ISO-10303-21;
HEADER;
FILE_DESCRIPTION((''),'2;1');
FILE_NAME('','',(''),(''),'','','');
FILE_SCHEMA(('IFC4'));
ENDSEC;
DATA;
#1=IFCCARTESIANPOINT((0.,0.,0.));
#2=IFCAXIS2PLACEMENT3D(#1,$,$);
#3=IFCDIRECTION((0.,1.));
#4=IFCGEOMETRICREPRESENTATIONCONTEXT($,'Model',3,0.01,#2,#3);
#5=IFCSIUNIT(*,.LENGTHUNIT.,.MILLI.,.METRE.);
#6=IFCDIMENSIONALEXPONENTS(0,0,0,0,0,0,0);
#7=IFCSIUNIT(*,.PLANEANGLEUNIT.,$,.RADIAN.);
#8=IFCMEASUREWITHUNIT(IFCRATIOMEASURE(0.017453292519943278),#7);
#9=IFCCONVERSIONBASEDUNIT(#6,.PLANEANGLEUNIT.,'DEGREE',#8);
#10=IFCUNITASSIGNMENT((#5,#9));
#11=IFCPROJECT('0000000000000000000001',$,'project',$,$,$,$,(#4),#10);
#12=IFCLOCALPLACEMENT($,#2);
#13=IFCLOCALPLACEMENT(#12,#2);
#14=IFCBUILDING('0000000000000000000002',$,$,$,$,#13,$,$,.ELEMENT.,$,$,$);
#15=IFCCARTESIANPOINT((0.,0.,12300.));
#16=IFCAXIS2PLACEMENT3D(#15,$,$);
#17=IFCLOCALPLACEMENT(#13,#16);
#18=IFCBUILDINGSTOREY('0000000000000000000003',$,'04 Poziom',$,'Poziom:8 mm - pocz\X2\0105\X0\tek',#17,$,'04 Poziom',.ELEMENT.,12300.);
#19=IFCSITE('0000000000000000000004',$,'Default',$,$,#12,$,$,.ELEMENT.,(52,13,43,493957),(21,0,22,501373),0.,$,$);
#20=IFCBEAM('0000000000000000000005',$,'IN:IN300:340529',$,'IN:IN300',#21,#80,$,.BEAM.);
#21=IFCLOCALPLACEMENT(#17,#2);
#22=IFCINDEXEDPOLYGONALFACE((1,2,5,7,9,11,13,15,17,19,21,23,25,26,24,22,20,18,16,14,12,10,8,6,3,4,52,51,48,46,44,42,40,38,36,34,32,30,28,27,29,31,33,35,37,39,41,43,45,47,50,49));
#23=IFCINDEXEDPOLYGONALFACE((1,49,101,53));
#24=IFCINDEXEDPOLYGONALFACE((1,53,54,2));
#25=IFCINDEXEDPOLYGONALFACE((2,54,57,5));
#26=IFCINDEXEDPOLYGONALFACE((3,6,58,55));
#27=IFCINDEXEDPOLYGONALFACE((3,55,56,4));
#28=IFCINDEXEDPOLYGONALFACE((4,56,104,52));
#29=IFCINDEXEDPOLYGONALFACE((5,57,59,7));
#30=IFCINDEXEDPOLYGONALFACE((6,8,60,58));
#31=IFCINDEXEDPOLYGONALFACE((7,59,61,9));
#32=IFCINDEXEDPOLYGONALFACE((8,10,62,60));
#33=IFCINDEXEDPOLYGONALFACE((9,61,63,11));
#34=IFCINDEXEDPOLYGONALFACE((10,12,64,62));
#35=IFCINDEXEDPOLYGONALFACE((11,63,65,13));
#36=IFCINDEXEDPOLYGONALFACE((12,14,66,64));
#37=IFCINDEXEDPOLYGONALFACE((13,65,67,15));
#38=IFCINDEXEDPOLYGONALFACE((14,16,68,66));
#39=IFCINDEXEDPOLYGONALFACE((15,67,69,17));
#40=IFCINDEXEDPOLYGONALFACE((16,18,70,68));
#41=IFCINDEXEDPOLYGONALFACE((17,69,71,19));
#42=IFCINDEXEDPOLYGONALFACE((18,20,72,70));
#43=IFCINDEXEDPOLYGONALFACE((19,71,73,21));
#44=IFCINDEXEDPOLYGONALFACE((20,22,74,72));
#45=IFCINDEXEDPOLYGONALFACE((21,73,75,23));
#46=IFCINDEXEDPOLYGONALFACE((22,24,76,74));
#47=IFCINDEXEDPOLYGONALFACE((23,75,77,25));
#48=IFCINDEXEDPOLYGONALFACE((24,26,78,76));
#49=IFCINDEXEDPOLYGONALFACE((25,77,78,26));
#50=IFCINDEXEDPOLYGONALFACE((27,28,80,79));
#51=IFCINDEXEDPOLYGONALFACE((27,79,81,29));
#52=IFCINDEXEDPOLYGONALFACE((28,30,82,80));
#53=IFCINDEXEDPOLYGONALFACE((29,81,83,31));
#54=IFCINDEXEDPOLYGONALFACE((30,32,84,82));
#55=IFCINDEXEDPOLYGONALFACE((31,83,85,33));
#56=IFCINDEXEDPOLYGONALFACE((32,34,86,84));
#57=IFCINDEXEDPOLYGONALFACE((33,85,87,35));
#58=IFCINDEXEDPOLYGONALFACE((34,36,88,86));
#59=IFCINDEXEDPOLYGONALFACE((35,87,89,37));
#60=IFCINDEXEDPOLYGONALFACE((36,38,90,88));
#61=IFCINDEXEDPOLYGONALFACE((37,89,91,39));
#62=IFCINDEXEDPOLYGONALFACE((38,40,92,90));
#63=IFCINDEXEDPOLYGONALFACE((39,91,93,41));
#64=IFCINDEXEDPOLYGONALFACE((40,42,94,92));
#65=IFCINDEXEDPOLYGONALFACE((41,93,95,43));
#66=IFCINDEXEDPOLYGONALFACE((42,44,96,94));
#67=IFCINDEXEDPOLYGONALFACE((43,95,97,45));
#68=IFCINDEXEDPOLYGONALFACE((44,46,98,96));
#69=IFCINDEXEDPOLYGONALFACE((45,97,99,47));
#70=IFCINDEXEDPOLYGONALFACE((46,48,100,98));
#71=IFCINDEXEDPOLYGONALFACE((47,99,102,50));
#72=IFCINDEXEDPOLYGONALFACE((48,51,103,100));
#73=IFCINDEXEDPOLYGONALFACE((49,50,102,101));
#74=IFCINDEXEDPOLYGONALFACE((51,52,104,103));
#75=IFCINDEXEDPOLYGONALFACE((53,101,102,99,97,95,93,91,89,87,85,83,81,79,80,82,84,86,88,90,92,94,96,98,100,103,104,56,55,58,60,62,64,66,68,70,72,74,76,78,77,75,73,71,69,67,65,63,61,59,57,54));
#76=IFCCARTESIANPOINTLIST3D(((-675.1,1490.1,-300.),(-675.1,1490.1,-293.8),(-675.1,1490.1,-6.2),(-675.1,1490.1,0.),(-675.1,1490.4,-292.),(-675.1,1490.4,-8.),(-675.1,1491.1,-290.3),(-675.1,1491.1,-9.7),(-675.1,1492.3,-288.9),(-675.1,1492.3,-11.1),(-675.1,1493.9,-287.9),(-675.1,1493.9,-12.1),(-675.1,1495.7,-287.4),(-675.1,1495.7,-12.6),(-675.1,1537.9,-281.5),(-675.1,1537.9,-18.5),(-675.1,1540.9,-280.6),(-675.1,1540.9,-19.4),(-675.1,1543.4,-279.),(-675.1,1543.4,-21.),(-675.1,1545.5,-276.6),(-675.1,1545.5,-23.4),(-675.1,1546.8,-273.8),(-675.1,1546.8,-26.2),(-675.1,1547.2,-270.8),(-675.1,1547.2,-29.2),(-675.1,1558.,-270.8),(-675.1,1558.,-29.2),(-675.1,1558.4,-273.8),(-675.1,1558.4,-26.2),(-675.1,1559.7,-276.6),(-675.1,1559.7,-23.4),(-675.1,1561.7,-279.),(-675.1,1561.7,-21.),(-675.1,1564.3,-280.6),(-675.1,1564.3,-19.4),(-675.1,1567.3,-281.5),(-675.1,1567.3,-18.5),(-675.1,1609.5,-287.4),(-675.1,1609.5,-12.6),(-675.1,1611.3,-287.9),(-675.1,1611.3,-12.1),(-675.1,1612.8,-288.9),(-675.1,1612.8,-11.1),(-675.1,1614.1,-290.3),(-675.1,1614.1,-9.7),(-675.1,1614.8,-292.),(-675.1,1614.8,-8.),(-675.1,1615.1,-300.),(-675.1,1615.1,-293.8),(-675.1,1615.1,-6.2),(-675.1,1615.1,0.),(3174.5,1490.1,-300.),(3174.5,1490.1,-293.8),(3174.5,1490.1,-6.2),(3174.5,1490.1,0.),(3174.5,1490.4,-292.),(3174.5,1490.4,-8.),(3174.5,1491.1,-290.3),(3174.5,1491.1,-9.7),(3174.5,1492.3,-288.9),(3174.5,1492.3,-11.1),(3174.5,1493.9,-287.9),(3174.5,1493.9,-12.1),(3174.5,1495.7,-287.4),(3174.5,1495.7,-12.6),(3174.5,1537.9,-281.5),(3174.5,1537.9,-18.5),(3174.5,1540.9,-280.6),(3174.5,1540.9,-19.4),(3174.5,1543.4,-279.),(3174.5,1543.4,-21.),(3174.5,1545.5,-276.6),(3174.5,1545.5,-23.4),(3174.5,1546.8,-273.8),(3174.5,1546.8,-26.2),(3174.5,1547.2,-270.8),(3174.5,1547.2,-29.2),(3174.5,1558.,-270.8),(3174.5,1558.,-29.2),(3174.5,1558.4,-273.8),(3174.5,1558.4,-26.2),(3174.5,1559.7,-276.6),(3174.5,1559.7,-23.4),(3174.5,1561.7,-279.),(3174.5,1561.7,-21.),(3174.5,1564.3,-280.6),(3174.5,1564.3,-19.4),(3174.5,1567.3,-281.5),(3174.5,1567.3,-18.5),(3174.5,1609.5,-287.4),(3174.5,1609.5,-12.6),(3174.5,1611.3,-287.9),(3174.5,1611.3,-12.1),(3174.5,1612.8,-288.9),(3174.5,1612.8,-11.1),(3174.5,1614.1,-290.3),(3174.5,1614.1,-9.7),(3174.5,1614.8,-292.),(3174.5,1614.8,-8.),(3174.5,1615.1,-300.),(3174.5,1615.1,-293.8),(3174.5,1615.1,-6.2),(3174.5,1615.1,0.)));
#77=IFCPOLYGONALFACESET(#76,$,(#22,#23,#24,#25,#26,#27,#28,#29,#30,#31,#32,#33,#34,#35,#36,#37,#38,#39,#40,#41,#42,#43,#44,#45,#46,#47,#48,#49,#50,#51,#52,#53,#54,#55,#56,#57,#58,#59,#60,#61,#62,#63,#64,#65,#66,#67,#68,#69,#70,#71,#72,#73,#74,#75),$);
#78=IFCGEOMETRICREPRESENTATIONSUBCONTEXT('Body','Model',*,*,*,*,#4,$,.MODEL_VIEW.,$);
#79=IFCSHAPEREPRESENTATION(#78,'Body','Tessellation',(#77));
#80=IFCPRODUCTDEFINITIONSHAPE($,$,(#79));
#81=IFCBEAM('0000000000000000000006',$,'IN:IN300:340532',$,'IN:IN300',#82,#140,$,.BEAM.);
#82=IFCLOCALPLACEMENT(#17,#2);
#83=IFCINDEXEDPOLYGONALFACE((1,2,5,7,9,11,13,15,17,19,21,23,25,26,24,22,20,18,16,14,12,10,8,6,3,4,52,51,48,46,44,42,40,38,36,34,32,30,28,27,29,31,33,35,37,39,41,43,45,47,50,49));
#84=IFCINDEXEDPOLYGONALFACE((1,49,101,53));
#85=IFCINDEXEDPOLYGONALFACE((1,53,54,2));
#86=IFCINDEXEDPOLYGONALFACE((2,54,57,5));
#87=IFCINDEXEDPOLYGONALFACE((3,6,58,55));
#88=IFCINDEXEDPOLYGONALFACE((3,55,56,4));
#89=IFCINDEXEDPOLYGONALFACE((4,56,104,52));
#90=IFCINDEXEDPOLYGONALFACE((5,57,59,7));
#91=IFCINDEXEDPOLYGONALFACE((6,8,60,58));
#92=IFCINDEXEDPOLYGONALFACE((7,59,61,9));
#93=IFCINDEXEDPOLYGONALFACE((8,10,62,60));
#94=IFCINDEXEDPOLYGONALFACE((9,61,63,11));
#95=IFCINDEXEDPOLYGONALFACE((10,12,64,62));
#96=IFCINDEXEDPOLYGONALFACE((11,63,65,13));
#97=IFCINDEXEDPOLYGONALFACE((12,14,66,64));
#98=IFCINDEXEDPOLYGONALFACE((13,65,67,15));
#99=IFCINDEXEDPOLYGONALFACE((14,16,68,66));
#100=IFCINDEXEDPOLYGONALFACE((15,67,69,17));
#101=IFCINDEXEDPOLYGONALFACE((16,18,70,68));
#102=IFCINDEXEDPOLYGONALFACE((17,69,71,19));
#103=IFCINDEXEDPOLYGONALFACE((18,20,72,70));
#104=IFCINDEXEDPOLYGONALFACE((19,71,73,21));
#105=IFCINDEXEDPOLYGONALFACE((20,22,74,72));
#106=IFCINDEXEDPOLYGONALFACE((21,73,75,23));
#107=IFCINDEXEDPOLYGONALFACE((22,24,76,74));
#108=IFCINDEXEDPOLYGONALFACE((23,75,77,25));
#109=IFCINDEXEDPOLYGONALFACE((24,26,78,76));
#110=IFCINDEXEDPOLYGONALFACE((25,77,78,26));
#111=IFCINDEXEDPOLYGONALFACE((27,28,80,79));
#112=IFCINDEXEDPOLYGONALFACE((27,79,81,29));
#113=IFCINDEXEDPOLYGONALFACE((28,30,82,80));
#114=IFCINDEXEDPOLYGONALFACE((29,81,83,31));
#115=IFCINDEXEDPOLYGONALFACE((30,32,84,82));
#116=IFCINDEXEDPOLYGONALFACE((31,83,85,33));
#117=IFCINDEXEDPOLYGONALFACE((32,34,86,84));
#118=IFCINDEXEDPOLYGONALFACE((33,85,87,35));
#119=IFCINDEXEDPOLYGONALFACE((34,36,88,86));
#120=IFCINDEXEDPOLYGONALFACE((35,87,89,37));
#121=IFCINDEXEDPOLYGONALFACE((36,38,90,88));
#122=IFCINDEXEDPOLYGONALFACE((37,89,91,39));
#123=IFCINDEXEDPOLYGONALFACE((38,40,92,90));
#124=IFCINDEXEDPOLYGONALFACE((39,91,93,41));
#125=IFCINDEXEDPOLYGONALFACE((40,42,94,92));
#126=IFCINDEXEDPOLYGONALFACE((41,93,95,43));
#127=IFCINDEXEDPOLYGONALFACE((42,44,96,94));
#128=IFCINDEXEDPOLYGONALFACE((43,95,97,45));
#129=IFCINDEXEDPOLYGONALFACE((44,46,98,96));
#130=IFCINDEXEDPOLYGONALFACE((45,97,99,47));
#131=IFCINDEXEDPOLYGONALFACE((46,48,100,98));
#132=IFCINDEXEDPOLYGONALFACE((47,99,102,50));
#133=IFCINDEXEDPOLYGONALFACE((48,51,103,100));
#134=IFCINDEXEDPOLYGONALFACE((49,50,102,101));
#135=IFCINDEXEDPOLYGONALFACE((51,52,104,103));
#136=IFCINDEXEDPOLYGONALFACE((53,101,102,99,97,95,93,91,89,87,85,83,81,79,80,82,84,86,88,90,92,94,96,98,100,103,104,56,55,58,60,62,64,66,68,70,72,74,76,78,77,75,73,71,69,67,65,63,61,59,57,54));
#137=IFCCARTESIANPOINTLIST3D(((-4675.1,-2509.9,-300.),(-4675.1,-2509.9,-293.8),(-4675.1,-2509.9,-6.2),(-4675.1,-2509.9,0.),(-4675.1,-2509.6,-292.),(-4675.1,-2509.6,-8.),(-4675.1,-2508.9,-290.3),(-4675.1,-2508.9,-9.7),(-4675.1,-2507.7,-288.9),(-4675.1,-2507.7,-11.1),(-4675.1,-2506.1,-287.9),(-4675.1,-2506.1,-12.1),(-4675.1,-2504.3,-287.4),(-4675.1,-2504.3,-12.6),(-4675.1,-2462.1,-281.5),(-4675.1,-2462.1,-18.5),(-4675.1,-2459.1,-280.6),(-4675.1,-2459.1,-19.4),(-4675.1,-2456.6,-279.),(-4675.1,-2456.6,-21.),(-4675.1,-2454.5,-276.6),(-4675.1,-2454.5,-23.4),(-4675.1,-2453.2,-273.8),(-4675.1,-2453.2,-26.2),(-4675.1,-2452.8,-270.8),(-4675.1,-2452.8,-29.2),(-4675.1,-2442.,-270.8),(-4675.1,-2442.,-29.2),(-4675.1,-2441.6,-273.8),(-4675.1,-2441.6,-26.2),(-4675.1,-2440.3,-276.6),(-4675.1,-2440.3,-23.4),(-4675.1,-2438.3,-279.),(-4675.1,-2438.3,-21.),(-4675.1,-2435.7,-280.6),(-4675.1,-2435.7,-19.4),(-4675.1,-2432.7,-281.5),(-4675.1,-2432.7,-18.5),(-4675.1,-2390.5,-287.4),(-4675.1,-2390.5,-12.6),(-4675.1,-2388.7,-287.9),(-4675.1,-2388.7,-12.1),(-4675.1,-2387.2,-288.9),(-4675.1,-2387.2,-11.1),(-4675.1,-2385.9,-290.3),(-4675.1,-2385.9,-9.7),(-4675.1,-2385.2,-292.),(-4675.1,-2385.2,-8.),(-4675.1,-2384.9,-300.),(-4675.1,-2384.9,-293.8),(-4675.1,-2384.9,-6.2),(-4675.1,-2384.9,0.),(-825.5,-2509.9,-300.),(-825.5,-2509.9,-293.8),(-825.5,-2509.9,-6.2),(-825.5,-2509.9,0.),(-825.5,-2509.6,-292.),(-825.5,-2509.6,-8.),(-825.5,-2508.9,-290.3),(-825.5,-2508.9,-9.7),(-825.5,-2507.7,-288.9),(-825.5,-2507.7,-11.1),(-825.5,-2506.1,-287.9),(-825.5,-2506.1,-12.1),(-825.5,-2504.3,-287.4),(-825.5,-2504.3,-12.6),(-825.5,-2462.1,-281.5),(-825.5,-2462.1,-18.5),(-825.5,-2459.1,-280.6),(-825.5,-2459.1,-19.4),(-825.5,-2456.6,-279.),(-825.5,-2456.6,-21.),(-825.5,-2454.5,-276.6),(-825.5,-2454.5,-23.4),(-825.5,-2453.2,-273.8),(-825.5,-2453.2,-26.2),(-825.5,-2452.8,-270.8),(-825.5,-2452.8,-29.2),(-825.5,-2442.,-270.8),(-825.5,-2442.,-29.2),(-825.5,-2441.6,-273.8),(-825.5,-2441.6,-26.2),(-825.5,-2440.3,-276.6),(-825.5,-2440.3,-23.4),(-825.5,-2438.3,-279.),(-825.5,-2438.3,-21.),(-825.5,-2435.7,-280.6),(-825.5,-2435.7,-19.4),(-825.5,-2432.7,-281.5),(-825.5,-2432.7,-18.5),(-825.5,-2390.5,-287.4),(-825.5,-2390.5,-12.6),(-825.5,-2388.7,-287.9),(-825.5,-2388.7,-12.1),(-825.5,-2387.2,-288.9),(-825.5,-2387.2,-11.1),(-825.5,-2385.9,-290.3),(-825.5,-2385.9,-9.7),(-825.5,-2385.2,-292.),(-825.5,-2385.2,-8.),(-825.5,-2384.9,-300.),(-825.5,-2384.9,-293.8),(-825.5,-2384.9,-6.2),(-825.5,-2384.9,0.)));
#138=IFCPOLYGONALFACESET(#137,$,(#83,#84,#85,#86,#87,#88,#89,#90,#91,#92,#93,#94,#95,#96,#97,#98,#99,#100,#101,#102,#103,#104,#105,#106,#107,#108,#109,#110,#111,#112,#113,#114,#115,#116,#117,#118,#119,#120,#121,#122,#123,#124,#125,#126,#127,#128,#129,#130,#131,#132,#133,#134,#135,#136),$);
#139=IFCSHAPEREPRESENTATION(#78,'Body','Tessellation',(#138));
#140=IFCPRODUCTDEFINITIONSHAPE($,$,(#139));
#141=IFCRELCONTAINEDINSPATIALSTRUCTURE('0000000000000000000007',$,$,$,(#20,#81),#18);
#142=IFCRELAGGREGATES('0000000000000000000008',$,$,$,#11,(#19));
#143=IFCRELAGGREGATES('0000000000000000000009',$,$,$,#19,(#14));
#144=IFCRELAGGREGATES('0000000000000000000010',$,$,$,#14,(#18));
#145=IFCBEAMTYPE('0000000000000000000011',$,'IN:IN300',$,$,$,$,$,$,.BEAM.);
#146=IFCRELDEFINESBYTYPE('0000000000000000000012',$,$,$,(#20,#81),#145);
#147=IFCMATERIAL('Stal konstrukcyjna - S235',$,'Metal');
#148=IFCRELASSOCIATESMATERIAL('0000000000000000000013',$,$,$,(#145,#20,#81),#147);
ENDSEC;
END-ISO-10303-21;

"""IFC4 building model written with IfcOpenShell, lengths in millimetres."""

from ifc_helpers import new_model, entity, si_unit, converted_unit, direction, frame, origin, place, context, subcontext, project, spatial, line, arc, indexed_curve, outline, extrude, source, transform, mapped, material, type_object, type_shapes, element, save


model = new_model("IFC4")

# Units and contexts
model_context = context("Model", 3, precision=0.01, world=origin(), true_north=direction((0.0, 1.0)))
body_context = subcontext(model_context, "Body", "Model", "MODEL_VIEW")
ifc_project = project(units=[si_unit("LENGTHUNIT", "METRE", prefix="MILLI"), converted_unit("PLANEANGLEUNIT", "DEGREE", entity("IfcRatioMeasure", 0.017453292519943278), si_unit("PLANEANGLEUNIT", "RADIAN"), dimensions=[0, 0, 0, 0, 0, 0, 0])], contexts=[model_context])

# Site, building, storey
site_placement = place(None, origin())
site = spatial("IfcSite", under=ifc_project, at=site_placement, Name="Default", CompositionType="ELEMENT", RefLatitude=(52, 13, 43, 493957), RefLongitude=(21, 0, 22, 501373), RefElevation=0.0)
building_placement = place(site_placement, origin())
building = spatial("IfcBuilding", under=site, at=building_placement, CompositionType="ELEMENT")
storey_placement = place(building_placement, frame((0.0, 0.0, 12300.0)))
storey = spatial("IfcBuildingStorey", under=building, at=storey_placement, Name="04 Poziom", ObjectType="Poziom:8 mm - początek", LongName="04 Poziom", CompositionType="ELEMENT", Elevation=12300.0)

# Shared definitions
ifc_material_1 = material(Name="Stal konstrukcyjna - S235", Category="Metal")

# Beams
beam_type_1 = type_object("IfcBeamType", Name="IN:IN300", PredefinedType="BEAM", material=ifc_material_1)
shared_shape_1 = source(origin(), body_context, "Body", "SweptSolid", [
    extrude(outline(indexed_curve([(143.8, -62.5), (150.0, -62.5), (150.0, 62.5), (143.8, 62.5), (139.6, 60.9), (137.4, 56.9), (131.5, 14.7), (127.9, 8.1), (120.8, 5.4), (-120.8, 5.4), (-127.9, 8.1), (-131.5, 14.7), (-137.4, 56.9), (-139.6, 60.9), (-143.8, 62.5), (-150.0, 62.5), (-150.0, -62.5), (-143.8, -62.5), (-139.6, -60.9), (-137.4, -56.9), (-131.5, -14.7), (-127.9, -8.1), (-120.8, -5.4), (120.8, -5.4), (127.9, -8.1), (131.5, -14.7), (137.4, -56.9), (139.6, -60.9)], segments=[line(1, 2, 3, 4), arc(4, 5, 6), line(6, 7), arc(7, 8, 9), line(9, 10), arc(10, 11, 12), line(12, 13), arc(13, 14, 15), line(15, 16, 17, 18), arc(18, 19, 20), line(20, 21), arc(21, 22, 23), line(23, 24), arc(24, 25, 26), line(26, 27), arc(27, 28, 1)], self_intersect=False)), frame((-1924.8, 0.0, 0.0), z_axis=(1.0, 0.0, 0.0), x_axis=(0.0, 0.0, -1.0)), (0.0, 0.0, 1.0), 3849.6),
])
type_shapes(beam_type_1, [shared_shape_1])
for number, where, name in (
    (1, (1249.7, 1552.6, -150.0), "IN:IN300:340529"),
    (2, (-2750.3, -2447.4, -150.0), "IN:IN300:340532"),
):
    element("IfcBeam", number, at=place(storey_placement, frame(where)), inside=storey, type_object=beam_type_1, material=ifc_material_1, Name=name, ObjectType="IN:IN300", PredefinedType="BEAM", context=body_context, shape_type="MappedRepresentation", body=[
        mapped(shared_shape_1, transform((0.0, 0.0, 0.0), scale=1.0)),
    ])

save(model, "model.ifc")
